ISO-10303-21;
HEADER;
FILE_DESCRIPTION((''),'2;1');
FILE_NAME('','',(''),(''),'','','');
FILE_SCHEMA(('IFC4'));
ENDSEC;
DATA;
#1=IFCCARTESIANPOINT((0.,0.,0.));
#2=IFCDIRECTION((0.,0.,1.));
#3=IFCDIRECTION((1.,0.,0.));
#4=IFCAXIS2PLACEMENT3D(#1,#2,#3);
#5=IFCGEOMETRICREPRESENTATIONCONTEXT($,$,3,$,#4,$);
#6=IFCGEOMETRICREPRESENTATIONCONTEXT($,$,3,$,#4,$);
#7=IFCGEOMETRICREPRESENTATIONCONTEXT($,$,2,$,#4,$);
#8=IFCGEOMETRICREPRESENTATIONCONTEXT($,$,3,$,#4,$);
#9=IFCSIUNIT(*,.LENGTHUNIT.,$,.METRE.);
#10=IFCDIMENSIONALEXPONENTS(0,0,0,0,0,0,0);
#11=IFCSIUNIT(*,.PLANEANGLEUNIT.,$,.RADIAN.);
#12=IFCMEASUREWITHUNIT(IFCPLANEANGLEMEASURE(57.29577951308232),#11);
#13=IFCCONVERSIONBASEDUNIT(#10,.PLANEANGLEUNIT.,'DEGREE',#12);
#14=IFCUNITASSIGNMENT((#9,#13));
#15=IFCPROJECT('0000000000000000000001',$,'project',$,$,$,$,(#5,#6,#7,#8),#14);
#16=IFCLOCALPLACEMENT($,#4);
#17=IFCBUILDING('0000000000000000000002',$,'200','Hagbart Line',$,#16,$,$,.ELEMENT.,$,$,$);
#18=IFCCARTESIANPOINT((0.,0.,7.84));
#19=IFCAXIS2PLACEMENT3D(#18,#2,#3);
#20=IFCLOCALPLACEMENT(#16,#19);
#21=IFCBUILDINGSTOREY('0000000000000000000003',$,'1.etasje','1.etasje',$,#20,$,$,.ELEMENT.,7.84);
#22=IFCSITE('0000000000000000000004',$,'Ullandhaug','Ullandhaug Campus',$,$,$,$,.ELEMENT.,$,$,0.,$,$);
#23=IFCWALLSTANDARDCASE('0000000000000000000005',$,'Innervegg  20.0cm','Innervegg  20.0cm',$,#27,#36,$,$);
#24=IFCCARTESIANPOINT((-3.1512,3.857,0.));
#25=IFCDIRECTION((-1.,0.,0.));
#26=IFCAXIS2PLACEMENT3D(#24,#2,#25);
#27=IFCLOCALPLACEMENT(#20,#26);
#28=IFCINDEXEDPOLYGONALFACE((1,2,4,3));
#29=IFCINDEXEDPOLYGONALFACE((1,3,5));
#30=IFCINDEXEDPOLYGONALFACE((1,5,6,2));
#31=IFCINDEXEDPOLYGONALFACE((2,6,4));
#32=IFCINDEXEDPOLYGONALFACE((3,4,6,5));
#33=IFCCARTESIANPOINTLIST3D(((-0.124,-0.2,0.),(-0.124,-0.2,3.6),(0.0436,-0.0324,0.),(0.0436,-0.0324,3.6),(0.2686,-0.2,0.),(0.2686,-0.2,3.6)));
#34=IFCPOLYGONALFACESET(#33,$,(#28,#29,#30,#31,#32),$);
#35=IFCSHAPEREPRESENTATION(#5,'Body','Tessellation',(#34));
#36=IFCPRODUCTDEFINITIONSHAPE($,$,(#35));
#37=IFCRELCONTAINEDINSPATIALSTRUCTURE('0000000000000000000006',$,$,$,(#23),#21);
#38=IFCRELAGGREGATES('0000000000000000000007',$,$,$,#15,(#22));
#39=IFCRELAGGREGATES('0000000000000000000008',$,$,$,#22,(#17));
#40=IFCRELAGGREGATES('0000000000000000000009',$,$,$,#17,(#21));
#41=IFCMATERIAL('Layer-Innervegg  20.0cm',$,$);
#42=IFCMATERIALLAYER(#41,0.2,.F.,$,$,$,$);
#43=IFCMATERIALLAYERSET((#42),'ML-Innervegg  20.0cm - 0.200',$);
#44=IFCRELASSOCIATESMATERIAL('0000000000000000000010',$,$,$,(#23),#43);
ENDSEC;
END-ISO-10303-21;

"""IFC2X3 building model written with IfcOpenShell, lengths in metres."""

from ifc_helpers import new_model, entity, si_unit, converted_unit, frame, origin_with_axes, place, context, project, spatial, polyline, outline, extrude, material, layer, layer_set, layer_usage, element, save


model = new_model("IFC2X3")

# Units and contexts
context_of_model_1 = context(None, 3, world=origin_with_axes())
context_of_model_2 = context(None, 3, world=origin_with_axes())
context_of_model_3 = context(None, 2, world=origin_with_axes())
context_of_model_4 = context(None, 3, world=origin_with_axes())
ifc_project = project(units=[si_unit("LENGTHUNIT", "METRE"), converted_unit("PLANEANGLEUNIT", "DEGREE", entity("IfcPlaneAngleMeasure", 57.29577951308232), si_unit("PLANEANGLEUNIT", "RADIAN"), dimensions=[0, 0, 0, 0, 0, 0, 0])], contexts=[context_of_model_1, context_of_model_2, context_of_model_3, context_of_model_4])

# Site, building, storey
site = spatial("IfcSite", under=ifc_project, Name="Ullandhaug", Description="Ullandhaug Campus", CompositionType="ELEMENT", RefElevation=0.0)
building_placement = place(None, origin_with_axes())
building = spatial("IfcBuilding", under=site, at=building_placement, Name="200", Description="Hagbart Line", CompositionType="ELEMENT")
storey_placement = place(building_placement, frame((0.0, 0.0, 7.84), z_axis=(0.0, 0.0, 1.0), x_axis=(1.0, 0.0, 0.0)))
storey = spatial("IfcBuildingStorey", under=building, at=storey_placement, Name="1.etasje", Description="1.etasje", CompositionType="ELEMENT", Elevation=7.84)

# Shared definitions
ifc_material_1 = material(Name="Layer-Innervegg  20.0cm")
ifc_layer_1 = layer(ifc_material_1, 0.2, ventilated=False)
ifc_layer_set_1 = layer_set([ifc_layer_1], Name="ML-Innervegg  20.0cm - 0.200")
ifc_layer_usage_1 = layer_usage(ifc_layer_set_1, "AXIS2", "POSITIVE", 0.0)

# Wall
wall_1_placement = place(storey_placement, frame((-3.1512, 3.857, 0.0), z_axis=(0.0, 0.0, 1.0), x_axis=(-1.0, 0.0, 0.0)))
element("IfcWallStandardCase", 1, at=wall_1_placement, inside=storey, material=ifc_layer_usage_1, Name="Innervegg  20.0cm", Description="Innervegg  20.0cm", context=context_of_model_1, shape_type="SweptSolid", body=[
    extrude(outline(polyline([(0.0, 0.0), (0.076, 0.0), (-0.124, 0.2), (0.2686, 0.2), (0.0, 0.0)])), frame((0.0, 0.0, 0.0), z_axis=(0.0, 0.0, -1.0), x_axis=(1.0, 0.0, 0.0)), (0.0, 0.0, -1.0), 3.6),
])

save(model, "model.ifc")
